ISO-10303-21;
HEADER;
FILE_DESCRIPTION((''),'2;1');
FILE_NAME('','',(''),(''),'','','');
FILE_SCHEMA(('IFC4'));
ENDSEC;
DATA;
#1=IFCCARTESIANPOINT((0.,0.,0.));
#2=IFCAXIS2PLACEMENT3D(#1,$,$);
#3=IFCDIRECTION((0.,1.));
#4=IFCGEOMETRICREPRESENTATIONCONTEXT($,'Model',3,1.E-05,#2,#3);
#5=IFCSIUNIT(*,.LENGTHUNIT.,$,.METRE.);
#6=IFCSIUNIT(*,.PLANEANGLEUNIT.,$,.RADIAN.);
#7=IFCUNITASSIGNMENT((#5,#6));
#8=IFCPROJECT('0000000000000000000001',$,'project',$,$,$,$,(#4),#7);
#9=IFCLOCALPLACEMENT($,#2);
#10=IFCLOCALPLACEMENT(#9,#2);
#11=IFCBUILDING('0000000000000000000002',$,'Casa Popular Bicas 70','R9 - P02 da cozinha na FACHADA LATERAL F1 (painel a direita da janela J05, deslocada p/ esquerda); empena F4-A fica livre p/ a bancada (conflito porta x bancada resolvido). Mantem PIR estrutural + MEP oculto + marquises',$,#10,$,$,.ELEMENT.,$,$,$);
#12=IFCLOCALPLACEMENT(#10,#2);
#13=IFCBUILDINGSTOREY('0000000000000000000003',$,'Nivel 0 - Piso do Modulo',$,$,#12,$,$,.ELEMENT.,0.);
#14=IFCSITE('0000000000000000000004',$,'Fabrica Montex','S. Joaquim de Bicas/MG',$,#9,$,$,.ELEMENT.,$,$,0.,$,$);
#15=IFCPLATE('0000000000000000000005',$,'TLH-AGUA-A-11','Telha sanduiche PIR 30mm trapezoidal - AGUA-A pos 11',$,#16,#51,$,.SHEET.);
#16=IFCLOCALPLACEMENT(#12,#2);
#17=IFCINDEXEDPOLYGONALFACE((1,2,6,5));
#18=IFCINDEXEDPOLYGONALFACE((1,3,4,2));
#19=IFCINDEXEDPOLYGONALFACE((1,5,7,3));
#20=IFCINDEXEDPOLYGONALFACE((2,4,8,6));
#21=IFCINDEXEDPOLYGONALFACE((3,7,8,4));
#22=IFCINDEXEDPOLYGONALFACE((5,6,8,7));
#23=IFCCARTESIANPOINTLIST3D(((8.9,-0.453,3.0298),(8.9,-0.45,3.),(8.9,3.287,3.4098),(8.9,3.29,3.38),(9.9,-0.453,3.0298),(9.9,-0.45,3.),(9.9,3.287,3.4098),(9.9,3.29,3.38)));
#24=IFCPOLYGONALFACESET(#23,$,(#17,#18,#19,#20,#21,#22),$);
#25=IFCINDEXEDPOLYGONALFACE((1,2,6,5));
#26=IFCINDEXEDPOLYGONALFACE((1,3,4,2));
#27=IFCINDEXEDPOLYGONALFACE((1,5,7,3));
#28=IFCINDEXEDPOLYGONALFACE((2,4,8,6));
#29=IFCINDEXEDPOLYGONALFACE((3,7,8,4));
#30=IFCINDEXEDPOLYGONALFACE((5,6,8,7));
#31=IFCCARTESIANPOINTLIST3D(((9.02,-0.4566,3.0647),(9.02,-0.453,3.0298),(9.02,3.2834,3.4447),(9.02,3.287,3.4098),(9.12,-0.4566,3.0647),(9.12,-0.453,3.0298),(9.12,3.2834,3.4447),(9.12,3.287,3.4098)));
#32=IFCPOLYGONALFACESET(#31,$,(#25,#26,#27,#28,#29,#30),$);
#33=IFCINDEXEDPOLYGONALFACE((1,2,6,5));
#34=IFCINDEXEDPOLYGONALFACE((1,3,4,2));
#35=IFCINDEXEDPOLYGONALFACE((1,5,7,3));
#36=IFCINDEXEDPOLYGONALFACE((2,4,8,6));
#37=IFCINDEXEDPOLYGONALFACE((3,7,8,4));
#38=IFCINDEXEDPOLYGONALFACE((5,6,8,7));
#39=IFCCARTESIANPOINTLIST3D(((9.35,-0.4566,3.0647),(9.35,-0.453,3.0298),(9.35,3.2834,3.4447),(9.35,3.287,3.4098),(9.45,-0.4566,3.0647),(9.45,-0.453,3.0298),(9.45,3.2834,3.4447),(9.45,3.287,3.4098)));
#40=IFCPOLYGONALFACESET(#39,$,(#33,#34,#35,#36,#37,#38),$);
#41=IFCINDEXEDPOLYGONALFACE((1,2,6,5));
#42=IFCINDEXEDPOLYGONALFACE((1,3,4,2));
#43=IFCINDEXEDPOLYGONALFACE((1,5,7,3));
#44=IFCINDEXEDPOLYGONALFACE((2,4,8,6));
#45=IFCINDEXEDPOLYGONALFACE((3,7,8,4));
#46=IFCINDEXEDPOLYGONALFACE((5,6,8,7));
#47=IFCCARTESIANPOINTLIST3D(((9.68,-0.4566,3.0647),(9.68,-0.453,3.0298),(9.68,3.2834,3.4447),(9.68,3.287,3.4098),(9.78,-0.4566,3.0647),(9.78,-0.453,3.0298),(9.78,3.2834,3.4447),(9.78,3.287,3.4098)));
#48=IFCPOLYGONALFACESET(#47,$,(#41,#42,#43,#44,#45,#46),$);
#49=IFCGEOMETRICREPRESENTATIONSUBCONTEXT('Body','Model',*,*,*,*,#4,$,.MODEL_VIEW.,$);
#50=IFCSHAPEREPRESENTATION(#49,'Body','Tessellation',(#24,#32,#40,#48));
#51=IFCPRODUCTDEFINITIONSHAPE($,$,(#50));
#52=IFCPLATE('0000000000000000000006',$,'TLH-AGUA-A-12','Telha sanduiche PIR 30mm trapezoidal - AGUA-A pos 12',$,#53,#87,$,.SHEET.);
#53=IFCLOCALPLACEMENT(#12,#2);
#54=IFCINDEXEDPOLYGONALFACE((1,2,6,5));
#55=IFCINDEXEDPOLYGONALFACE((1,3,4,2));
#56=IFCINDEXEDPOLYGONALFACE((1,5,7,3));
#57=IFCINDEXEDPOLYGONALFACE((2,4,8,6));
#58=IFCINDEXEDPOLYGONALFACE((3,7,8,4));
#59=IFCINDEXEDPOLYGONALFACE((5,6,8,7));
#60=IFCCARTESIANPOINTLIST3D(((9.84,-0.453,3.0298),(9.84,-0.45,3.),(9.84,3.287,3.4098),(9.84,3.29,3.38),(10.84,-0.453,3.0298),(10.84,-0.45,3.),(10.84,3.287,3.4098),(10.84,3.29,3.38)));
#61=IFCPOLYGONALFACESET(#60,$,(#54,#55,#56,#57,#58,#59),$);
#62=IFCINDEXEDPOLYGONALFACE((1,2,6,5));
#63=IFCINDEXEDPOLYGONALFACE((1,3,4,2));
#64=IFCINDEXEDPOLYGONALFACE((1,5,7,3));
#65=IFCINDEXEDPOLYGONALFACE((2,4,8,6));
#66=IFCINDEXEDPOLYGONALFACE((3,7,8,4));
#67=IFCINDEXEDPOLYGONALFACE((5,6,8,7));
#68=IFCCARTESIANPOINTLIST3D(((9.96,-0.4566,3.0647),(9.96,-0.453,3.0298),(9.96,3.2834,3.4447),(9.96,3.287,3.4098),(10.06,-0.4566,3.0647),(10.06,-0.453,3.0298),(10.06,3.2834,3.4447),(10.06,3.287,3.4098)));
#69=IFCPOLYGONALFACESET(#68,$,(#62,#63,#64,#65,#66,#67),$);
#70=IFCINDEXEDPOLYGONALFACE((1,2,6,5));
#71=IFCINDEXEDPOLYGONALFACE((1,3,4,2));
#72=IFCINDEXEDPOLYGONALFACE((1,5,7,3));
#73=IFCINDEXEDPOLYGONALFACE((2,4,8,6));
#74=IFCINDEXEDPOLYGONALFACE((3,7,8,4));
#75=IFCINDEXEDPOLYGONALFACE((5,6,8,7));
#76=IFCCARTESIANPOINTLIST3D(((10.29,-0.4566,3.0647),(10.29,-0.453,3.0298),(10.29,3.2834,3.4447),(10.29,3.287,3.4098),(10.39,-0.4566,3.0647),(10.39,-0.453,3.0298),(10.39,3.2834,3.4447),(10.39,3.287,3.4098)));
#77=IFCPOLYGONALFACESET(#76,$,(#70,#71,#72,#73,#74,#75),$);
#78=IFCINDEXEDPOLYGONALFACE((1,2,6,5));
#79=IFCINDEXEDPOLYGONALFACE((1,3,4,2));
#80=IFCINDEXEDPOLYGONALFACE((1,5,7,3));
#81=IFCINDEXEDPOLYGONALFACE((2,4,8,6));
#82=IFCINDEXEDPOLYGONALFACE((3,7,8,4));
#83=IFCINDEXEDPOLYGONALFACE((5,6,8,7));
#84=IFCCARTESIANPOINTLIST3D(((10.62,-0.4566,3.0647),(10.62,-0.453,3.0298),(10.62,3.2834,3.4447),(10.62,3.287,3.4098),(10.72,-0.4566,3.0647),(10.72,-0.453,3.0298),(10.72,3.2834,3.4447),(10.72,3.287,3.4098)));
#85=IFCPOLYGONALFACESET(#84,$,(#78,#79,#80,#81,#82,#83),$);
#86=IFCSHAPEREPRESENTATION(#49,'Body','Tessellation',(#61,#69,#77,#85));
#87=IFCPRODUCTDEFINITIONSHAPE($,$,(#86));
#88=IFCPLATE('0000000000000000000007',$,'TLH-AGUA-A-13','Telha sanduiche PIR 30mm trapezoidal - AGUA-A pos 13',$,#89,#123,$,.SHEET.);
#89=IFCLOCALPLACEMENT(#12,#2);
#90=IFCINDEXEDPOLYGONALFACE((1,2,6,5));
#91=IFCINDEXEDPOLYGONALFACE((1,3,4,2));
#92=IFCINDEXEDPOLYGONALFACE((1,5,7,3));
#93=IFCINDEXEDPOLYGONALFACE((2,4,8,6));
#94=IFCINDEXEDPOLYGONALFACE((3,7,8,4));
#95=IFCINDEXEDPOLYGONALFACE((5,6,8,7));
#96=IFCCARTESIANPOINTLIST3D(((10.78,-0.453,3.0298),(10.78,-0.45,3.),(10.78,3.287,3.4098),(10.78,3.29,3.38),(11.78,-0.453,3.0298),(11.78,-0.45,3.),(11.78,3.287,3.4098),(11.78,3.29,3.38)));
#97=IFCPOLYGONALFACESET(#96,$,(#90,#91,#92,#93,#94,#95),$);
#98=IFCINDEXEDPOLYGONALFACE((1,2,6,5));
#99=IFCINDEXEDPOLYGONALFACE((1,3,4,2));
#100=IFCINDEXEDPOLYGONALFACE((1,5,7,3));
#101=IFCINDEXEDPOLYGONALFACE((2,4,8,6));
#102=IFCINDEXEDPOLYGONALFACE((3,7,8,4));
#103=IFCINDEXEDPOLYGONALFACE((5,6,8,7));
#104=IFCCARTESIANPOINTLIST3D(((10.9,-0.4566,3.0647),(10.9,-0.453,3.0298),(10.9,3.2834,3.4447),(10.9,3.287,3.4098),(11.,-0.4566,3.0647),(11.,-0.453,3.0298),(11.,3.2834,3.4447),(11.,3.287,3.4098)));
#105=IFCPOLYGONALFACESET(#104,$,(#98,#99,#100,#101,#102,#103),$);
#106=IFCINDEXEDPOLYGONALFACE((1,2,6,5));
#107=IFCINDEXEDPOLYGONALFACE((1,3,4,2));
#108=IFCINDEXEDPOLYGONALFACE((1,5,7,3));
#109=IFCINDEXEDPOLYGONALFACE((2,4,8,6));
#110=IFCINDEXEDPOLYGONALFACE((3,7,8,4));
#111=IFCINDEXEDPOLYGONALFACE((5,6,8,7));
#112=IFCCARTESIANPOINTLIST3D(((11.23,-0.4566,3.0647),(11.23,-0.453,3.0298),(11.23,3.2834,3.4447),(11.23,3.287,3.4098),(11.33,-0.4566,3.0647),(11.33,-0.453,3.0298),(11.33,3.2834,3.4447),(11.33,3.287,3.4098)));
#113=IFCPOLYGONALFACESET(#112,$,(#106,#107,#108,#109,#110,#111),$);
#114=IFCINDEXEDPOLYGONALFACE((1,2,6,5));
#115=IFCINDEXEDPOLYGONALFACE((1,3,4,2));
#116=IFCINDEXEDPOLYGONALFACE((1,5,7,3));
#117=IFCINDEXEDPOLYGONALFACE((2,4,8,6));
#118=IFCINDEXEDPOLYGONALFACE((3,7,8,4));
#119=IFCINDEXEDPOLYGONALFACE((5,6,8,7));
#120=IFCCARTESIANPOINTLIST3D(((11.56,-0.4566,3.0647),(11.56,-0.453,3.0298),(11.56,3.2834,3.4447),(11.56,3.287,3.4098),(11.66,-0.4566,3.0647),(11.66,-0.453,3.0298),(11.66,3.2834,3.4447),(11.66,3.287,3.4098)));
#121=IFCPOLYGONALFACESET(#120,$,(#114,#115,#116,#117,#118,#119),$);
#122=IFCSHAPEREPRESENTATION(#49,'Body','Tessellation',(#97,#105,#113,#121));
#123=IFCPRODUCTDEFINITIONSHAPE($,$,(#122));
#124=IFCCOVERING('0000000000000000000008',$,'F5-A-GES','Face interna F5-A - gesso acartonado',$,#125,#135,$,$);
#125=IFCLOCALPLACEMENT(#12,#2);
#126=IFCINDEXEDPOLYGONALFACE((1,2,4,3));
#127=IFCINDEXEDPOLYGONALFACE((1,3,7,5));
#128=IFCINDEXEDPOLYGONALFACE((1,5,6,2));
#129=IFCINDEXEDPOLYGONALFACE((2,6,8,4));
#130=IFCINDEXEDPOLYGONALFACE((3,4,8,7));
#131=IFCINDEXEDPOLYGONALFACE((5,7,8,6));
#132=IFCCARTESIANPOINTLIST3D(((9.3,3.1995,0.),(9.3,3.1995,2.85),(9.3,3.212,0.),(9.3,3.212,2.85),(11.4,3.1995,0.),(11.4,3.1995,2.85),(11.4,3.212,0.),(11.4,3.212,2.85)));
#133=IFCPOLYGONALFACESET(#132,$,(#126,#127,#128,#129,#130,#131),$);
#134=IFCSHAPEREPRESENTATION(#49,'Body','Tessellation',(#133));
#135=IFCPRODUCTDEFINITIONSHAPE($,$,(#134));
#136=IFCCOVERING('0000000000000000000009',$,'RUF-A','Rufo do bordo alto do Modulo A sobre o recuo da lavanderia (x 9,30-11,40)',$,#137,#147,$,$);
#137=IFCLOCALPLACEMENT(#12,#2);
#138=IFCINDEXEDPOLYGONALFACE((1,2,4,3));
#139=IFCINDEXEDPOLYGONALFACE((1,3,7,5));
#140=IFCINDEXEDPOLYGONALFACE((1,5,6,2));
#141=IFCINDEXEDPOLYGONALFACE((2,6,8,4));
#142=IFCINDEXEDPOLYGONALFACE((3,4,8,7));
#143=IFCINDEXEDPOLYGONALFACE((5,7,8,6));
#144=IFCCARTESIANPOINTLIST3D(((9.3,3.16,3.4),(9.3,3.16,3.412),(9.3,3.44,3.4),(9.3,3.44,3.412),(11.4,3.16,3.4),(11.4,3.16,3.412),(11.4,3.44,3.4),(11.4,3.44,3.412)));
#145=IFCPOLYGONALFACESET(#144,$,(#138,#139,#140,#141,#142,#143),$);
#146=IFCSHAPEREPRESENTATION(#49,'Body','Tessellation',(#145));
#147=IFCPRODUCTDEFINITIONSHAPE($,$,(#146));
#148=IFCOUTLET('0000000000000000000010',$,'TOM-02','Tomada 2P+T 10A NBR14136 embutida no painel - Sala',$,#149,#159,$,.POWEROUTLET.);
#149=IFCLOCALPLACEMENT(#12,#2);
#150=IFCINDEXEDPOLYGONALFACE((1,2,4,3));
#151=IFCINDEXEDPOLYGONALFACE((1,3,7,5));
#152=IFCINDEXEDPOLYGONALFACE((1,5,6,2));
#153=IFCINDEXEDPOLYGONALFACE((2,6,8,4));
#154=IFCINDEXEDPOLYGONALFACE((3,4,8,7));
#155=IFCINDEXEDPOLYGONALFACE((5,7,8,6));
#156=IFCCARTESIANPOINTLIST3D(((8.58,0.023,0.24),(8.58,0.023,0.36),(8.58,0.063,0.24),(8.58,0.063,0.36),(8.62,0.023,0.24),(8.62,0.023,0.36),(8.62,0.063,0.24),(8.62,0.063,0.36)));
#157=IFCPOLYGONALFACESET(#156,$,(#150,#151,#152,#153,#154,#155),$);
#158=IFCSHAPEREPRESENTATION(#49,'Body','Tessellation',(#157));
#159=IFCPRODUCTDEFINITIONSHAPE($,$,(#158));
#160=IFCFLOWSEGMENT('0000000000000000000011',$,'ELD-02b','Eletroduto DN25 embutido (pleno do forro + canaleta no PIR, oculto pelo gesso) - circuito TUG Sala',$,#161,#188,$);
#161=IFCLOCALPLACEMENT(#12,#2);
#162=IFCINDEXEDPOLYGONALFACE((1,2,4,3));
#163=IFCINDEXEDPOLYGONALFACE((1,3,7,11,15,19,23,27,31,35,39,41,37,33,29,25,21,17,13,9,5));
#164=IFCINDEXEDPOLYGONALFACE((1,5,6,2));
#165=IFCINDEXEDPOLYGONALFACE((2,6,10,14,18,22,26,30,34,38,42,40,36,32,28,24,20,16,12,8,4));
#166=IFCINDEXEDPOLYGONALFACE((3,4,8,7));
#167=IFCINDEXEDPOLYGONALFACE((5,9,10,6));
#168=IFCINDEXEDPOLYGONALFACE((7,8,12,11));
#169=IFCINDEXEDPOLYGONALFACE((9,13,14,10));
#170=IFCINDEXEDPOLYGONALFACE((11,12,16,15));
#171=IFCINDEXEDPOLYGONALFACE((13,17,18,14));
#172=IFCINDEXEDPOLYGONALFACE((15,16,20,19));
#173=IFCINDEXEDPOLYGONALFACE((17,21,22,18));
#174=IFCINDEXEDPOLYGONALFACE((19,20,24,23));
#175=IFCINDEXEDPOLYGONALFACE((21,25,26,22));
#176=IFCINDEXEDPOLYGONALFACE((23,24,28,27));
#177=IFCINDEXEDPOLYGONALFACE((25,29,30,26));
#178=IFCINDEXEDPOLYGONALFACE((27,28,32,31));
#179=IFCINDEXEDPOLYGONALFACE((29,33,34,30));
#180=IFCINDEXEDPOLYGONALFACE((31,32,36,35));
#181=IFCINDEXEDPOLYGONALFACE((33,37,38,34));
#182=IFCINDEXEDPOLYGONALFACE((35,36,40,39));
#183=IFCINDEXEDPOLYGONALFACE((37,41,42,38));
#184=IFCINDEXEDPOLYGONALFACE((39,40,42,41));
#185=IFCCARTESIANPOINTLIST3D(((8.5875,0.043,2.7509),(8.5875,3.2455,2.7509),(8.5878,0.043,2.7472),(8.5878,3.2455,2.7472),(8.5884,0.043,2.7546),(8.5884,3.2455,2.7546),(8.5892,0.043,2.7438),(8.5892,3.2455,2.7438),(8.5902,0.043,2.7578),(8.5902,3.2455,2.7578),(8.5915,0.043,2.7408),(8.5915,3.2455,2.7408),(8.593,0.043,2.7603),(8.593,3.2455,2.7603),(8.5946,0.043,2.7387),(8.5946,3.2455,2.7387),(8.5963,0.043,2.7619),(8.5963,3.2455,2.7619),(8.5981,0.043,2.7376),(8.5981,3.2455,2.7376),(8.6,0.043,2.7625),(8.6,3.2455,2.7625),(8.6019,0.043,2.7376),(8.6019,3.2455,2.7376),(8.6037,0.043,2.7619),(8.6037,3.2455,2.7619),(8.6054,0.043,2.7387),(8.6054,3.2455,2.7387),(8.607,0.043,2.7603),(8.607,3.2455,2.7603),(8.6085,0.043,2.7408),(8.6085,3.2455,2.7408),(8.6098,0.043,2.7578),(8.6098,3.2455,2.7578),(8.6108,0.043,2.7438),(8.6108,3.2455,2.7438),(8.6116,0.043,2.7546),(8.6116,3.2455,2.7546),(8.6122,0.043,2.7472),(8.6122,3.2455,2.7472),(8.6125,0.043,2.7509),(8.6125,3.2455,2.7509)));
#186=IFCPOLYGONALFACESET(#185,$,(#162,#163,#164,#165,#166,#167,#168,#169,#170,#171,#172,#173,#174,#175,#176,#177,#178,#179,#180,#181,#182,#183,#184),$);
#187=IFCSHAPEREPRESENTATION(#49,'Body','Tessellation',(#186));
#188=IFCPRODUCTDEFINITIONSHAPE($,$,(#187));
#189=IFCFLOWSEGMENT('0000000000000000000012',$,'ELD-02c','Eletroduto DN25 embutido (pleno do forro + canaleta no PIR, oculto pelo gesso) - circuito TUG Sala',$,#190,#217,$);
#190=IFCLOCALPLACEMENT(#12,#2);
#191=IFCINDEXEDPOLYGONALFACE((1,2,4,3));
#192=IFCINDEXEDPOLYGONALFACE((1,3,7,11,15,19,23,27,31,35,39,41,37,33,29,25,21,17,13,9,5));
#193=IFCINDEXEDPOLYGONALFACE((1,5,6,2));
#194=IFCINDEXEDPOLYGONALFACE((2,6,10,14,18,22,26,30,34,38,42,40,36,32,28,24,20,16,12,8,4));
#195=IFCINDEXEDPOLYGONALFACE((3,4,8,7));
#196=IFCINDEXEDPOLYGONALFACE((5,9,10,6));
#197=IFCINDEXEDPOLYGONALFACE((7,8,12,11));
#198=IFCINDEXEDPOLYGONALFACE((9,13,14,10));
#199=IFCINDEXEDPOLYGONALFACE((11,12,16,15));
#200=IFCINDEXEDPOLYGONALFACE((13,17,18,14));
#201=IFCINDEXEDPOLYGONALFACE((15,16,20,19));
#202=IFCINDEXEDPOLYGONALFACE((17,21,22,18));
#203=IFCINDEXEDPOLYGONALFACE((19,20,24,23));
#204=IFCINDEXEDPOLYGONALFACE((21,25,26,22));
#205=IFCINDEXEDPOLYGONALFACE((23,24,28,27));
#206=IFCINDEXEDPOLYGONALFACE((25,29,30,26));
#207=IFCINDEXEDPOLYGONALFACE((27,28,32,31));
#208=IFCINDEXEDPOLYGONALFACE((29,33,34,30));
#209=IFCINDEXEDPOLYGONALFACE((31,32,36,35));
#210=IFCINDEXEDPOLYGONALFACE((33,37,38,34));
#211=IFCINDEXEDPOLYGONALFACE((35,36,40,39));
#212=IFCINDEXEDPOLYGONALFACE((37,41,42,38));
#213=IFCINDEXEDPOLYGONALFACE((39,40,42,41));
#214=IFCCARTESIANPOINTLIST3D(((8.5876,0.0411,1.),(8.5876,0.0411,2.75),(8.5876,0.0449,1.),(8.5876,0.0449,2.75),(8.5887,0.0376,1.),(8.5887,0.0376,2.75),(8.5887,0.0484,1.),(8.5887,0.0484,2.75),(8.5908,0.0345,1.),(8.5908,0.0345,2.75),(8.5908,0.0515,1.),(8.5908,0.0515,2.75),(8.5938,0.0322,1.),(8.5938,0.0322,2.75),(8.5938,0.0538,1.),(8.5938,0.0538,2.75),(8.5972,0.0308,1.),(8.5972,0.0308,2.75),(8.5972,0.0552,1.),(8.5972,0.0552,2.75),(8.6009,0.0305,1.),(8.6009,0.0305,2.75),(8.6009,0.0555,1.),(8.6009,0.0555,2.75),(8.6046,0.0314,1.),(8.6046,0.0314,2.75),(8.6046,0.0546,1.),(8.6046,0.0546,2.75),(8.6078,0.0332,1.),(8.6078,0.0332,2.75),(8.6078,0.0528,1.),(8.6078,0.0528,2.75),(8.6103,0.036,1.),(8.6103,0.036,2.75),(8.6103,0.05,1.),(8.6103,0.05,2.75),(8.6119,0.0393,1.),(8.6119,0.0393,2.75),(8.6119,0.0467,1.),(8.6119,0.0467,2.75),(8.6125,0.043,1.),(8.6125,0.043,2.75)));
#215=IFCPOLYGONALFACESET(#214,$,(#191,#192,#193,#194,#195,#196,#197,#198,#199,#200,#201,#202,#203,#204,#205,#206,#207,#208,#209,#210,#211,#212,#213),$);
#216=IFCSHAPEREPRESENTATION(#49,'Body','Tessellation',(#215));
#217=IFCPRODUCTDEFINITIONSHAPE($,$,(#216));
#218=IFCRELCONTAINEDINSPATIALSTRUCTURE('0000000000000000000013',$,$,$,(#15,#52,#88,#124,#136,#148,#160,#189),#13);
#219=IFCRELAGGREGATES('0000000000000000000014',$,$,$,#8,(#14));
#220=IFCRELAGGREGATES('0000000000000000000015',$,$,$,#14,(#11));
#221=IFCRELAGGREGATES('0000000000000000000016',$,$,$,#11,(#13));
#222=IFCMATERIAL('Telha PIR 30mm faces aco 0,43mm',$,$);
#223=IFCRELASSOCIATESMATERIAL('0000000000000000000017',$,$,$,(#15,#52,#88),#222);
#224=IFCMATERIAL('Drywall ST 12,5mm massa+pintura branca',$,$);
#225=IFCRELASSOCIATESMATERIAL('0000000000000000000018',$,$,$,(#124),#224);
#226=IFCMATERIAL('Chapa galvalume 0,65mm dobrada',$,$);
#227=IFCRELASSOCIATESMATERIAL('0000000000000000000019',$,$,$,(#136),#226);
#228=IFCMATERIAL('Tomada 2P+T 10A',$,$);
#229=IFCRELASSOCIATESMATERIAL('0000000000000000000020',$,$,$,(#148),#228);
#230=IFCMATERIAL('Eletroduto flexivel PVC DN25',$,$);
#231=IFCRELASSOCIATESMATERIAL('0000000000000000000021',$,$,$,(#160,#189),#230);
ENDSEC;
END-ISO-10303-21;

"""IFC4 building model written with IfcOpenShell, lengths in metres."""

from ifc_helpers import new_model, si_unit, direction, frame, frame_2d, origin, origin_2d, place, context, subcontext, project, spatial, rectangle, circle, extrude, material, element, save


model = new_model("IFC4")

# Units and contexts
model_context = context("Model", 3, precision=1e-05, world=origin(), true_north=direction((0.0, 1.0)))
body_context = subcontext(model_context, "Body", "Model", "MODEL_VIEW")
ifc_project = project(units=[si_unit("LENGTHUNIT", "METRE"), si_unit("PLANEANGLEUNIT", "RADIAN")], contexts=[model_context])

# Site, building, storey
site_placement = place(None, origin())
site = spatial("IfcSite", under=ifc_project, at=site_placement, Name="Fabrica Montex", Description="S. Joaquim de Bicas/MG", CompositionType="ELEMENT", RefElevation=0.0)
building_placement = place(site_placement, origin())
building = spatial("IfcBuilding", under=site, at=building_placement, Name="Casa Popular Bicas 70", Description="R9 - P02 da cozinha na FACHADA LATERAL F1 (painel a direita da janela J05, deslocada p/ esquerda); empena F4-A fica livre p/ a bancada (conflito porta x bancada resolvido). Mantem PIR estrutural + MEP oculto + marquises", CompositionType="ELEMENT")
storey_placement = place(building_placement, origin())
storey = spatial("IfcBuildingStorey", under=building, at=storey_placement, Name="Nivel 0 - Piso do Modulo", CompositionType="ELEMENT", Elevation=0.0)

# Plates
ifc_material_1 = material(Name="Telha PIR 30mm faces aco 0,43mm")
for number, where, z_axis, x_axis, name, description in (
    (1, (8.9, -0.45, 3.0), (0.0, -0.101084, 0.994878), (1.0, 0.0, 0.0), "TLH-AGUA-A-11", "Telha sanduiche PIR 30mm trapezoidal - AGUA-A pos 11"),
    (2, (9.84, -0.45, 3.0), (0.0, -0.101084, 0.994878), (1.0, 0.0, 0.0), "TLH-AGUA-A-12", "Telha sanduiche PIR 30mm trapezoidal - AGUA-A pos 12"),
    (3, (10.78, -0.45, 3.0), (0.0, -0.101084, 0.994878), (1.0, 0.0, 0.0), "TLH-AGUA-A-13", "Telha sanduiche PIR 30mm trapezoidal - AGUA-A pos 13"),
):
    element("IfcPlate", number, at=place(storey_placement, frame(where, z_axis=z_axis, x_axis=x_axis)), inside=storey, material=ifc_material_1, Name=name, Description=description, PredefinedType="SHEET", context=body_context, shape_type="SweptSolid", body=[
        extrude(rectangle(XDim=1.0, YDim=3.7593, at=frame_2d((0.5, 1.8796))), origin(), (0.0, 0.0, 1.0), 0.03),
        extrude(rectangle(XDim=0.1, YDim=3.7593, at=frame_2d((0.17, 1.8796))), frame((0.0, 0.0, 0.03)), (0.0, 0.0, 1.0), 0.035),
        extrude(rectangle(XDim=0.1, YDim=3.7593, at=frame_2d((0.5, 1.8796))), frame((0.0, 0.0, 0.03)), (0.0, 0.0, 1.0), 0.035),
        extrude(rectangle(XDim=0.1, YDim=3.7593, at=frame_2d((0.83, 1.8796))), frame((0.0, 0.0, 0.03)), (0.0, 0.0, 1.0), 0.035),
    ])

# Coverings
ifc_material_2 = material(Name="Drywall ST 12,5mm massa+pintura branca")
covering_1_placement = place(storey_placement, frame((9.3, 3.2058, 0.0), x_axis=(1.0, 0.0, 0.0)))
element("IfcCovering", 4, at=covering_1_placement, inside=storey, material=ifc_material_2, Name="F5-A-GES", Description="Face interna F5-A - gesso acartonado", context=body_context, shape_type="SweptSolid", body=[
    extrude(rectangle(XDim=2.1, YDim=0.0125, at=frame_2d((1.05, 0.0))), origin(), (0.0, 0.0, 1.0), 2.85),
])
ifc_material_3 = material(Name="Chapa galvalume 0,65mm dobrada")
covering_2_placement = place(storey_placement, frame((9.3, 3.16, 3.4), x_axis=(1.0, 0.0, 0.0)))
element("IfcCovering", 5, at=covering_2_placement, inside=storey, material=ifc_material_3, Name="RUF-A", Description="Rufo do bordo alto do Modulo A sobre o recuo da lavanderia (x 9,30-11,40)", context=body_context, shape_type="SweptSolid", body=[
    extrude(rectangle(XDim=2.1, YDim=0.28, at=frame_2d((1.05, 0.14))), origin(), (0.0, 0.0, 1.0), 0.012),
])

# Outlet
ifc_material_4 = material(Name="Tomada 2P+T 10A")
outlet_placement = place(storey_placement, frame((8.58, 0.023, 0.24)))
element("IfcOutlet", 6, at=outlet_placement, inside=storey, material=ifc_material_4, Name="TOM-02", Description="Tomada 2P+T 10A NBR14136 embutida no painel - Sala", PredefinedType="POWEROUTLET", context=body_context, shape_type="SweptSolid", body=[
    extrude(rectangle(XDim=0.04, YDim=0.04, at=frame_2d((0.02, 0.02))), origin(), (0.0, 0.0, 1.0), 0.12),
])

# Flow segments
ifc_material_5 = material(Name="Eletroduto flexivel PVC DN25")
flow_segment_1_placement = place(storey_placement, frame((8.6, 3.2455, 2.75), z_axis=(0.0, -1.0, 0.0), x_axis=(0.0, 0.0, 1.0)))
element("IfcFlowSegment", 7, at=flow_segment_1_placement, inside=storey, material=ifc_material_5, Name="ELD-02b", Description="Eletroduto DN25 embutido (pleno do forro + canaleta no PIR, oculto pelo gesso) - circuito TUG Sala", context=body_context, shape_type="SweptSolid", body=[
    extrude(circle(Radius=0.0125, at=origin_2d()), origin(), (0.0, 0.0, 1.0), 3.2025),
])
flow_segment_2_placement = place(storey_placement, frame((8.6, 0.043, 2.75), z_axis=(0.0, 0.0, -1.0), x_axis=(1.0, 0.0, 0.0)))
element("IfcFlowSegment", 8, at=flow_segment_2_placement, inside=storey, material=ifc_material_5, Name="ELD-02c", Description="Eletroduto DN25 embutido (pleno do forro + canaleta no PIR, oculto pelo gesso) - circuito TUG Sala", context=body_context, shape_type="SweptSolid", body=[
    extrude(circle(Radius=0.0125, at=origin_2d()), origin(), (0.0, 0.0, 1.0), 1.75),
])

save(model, "model.ifc")
